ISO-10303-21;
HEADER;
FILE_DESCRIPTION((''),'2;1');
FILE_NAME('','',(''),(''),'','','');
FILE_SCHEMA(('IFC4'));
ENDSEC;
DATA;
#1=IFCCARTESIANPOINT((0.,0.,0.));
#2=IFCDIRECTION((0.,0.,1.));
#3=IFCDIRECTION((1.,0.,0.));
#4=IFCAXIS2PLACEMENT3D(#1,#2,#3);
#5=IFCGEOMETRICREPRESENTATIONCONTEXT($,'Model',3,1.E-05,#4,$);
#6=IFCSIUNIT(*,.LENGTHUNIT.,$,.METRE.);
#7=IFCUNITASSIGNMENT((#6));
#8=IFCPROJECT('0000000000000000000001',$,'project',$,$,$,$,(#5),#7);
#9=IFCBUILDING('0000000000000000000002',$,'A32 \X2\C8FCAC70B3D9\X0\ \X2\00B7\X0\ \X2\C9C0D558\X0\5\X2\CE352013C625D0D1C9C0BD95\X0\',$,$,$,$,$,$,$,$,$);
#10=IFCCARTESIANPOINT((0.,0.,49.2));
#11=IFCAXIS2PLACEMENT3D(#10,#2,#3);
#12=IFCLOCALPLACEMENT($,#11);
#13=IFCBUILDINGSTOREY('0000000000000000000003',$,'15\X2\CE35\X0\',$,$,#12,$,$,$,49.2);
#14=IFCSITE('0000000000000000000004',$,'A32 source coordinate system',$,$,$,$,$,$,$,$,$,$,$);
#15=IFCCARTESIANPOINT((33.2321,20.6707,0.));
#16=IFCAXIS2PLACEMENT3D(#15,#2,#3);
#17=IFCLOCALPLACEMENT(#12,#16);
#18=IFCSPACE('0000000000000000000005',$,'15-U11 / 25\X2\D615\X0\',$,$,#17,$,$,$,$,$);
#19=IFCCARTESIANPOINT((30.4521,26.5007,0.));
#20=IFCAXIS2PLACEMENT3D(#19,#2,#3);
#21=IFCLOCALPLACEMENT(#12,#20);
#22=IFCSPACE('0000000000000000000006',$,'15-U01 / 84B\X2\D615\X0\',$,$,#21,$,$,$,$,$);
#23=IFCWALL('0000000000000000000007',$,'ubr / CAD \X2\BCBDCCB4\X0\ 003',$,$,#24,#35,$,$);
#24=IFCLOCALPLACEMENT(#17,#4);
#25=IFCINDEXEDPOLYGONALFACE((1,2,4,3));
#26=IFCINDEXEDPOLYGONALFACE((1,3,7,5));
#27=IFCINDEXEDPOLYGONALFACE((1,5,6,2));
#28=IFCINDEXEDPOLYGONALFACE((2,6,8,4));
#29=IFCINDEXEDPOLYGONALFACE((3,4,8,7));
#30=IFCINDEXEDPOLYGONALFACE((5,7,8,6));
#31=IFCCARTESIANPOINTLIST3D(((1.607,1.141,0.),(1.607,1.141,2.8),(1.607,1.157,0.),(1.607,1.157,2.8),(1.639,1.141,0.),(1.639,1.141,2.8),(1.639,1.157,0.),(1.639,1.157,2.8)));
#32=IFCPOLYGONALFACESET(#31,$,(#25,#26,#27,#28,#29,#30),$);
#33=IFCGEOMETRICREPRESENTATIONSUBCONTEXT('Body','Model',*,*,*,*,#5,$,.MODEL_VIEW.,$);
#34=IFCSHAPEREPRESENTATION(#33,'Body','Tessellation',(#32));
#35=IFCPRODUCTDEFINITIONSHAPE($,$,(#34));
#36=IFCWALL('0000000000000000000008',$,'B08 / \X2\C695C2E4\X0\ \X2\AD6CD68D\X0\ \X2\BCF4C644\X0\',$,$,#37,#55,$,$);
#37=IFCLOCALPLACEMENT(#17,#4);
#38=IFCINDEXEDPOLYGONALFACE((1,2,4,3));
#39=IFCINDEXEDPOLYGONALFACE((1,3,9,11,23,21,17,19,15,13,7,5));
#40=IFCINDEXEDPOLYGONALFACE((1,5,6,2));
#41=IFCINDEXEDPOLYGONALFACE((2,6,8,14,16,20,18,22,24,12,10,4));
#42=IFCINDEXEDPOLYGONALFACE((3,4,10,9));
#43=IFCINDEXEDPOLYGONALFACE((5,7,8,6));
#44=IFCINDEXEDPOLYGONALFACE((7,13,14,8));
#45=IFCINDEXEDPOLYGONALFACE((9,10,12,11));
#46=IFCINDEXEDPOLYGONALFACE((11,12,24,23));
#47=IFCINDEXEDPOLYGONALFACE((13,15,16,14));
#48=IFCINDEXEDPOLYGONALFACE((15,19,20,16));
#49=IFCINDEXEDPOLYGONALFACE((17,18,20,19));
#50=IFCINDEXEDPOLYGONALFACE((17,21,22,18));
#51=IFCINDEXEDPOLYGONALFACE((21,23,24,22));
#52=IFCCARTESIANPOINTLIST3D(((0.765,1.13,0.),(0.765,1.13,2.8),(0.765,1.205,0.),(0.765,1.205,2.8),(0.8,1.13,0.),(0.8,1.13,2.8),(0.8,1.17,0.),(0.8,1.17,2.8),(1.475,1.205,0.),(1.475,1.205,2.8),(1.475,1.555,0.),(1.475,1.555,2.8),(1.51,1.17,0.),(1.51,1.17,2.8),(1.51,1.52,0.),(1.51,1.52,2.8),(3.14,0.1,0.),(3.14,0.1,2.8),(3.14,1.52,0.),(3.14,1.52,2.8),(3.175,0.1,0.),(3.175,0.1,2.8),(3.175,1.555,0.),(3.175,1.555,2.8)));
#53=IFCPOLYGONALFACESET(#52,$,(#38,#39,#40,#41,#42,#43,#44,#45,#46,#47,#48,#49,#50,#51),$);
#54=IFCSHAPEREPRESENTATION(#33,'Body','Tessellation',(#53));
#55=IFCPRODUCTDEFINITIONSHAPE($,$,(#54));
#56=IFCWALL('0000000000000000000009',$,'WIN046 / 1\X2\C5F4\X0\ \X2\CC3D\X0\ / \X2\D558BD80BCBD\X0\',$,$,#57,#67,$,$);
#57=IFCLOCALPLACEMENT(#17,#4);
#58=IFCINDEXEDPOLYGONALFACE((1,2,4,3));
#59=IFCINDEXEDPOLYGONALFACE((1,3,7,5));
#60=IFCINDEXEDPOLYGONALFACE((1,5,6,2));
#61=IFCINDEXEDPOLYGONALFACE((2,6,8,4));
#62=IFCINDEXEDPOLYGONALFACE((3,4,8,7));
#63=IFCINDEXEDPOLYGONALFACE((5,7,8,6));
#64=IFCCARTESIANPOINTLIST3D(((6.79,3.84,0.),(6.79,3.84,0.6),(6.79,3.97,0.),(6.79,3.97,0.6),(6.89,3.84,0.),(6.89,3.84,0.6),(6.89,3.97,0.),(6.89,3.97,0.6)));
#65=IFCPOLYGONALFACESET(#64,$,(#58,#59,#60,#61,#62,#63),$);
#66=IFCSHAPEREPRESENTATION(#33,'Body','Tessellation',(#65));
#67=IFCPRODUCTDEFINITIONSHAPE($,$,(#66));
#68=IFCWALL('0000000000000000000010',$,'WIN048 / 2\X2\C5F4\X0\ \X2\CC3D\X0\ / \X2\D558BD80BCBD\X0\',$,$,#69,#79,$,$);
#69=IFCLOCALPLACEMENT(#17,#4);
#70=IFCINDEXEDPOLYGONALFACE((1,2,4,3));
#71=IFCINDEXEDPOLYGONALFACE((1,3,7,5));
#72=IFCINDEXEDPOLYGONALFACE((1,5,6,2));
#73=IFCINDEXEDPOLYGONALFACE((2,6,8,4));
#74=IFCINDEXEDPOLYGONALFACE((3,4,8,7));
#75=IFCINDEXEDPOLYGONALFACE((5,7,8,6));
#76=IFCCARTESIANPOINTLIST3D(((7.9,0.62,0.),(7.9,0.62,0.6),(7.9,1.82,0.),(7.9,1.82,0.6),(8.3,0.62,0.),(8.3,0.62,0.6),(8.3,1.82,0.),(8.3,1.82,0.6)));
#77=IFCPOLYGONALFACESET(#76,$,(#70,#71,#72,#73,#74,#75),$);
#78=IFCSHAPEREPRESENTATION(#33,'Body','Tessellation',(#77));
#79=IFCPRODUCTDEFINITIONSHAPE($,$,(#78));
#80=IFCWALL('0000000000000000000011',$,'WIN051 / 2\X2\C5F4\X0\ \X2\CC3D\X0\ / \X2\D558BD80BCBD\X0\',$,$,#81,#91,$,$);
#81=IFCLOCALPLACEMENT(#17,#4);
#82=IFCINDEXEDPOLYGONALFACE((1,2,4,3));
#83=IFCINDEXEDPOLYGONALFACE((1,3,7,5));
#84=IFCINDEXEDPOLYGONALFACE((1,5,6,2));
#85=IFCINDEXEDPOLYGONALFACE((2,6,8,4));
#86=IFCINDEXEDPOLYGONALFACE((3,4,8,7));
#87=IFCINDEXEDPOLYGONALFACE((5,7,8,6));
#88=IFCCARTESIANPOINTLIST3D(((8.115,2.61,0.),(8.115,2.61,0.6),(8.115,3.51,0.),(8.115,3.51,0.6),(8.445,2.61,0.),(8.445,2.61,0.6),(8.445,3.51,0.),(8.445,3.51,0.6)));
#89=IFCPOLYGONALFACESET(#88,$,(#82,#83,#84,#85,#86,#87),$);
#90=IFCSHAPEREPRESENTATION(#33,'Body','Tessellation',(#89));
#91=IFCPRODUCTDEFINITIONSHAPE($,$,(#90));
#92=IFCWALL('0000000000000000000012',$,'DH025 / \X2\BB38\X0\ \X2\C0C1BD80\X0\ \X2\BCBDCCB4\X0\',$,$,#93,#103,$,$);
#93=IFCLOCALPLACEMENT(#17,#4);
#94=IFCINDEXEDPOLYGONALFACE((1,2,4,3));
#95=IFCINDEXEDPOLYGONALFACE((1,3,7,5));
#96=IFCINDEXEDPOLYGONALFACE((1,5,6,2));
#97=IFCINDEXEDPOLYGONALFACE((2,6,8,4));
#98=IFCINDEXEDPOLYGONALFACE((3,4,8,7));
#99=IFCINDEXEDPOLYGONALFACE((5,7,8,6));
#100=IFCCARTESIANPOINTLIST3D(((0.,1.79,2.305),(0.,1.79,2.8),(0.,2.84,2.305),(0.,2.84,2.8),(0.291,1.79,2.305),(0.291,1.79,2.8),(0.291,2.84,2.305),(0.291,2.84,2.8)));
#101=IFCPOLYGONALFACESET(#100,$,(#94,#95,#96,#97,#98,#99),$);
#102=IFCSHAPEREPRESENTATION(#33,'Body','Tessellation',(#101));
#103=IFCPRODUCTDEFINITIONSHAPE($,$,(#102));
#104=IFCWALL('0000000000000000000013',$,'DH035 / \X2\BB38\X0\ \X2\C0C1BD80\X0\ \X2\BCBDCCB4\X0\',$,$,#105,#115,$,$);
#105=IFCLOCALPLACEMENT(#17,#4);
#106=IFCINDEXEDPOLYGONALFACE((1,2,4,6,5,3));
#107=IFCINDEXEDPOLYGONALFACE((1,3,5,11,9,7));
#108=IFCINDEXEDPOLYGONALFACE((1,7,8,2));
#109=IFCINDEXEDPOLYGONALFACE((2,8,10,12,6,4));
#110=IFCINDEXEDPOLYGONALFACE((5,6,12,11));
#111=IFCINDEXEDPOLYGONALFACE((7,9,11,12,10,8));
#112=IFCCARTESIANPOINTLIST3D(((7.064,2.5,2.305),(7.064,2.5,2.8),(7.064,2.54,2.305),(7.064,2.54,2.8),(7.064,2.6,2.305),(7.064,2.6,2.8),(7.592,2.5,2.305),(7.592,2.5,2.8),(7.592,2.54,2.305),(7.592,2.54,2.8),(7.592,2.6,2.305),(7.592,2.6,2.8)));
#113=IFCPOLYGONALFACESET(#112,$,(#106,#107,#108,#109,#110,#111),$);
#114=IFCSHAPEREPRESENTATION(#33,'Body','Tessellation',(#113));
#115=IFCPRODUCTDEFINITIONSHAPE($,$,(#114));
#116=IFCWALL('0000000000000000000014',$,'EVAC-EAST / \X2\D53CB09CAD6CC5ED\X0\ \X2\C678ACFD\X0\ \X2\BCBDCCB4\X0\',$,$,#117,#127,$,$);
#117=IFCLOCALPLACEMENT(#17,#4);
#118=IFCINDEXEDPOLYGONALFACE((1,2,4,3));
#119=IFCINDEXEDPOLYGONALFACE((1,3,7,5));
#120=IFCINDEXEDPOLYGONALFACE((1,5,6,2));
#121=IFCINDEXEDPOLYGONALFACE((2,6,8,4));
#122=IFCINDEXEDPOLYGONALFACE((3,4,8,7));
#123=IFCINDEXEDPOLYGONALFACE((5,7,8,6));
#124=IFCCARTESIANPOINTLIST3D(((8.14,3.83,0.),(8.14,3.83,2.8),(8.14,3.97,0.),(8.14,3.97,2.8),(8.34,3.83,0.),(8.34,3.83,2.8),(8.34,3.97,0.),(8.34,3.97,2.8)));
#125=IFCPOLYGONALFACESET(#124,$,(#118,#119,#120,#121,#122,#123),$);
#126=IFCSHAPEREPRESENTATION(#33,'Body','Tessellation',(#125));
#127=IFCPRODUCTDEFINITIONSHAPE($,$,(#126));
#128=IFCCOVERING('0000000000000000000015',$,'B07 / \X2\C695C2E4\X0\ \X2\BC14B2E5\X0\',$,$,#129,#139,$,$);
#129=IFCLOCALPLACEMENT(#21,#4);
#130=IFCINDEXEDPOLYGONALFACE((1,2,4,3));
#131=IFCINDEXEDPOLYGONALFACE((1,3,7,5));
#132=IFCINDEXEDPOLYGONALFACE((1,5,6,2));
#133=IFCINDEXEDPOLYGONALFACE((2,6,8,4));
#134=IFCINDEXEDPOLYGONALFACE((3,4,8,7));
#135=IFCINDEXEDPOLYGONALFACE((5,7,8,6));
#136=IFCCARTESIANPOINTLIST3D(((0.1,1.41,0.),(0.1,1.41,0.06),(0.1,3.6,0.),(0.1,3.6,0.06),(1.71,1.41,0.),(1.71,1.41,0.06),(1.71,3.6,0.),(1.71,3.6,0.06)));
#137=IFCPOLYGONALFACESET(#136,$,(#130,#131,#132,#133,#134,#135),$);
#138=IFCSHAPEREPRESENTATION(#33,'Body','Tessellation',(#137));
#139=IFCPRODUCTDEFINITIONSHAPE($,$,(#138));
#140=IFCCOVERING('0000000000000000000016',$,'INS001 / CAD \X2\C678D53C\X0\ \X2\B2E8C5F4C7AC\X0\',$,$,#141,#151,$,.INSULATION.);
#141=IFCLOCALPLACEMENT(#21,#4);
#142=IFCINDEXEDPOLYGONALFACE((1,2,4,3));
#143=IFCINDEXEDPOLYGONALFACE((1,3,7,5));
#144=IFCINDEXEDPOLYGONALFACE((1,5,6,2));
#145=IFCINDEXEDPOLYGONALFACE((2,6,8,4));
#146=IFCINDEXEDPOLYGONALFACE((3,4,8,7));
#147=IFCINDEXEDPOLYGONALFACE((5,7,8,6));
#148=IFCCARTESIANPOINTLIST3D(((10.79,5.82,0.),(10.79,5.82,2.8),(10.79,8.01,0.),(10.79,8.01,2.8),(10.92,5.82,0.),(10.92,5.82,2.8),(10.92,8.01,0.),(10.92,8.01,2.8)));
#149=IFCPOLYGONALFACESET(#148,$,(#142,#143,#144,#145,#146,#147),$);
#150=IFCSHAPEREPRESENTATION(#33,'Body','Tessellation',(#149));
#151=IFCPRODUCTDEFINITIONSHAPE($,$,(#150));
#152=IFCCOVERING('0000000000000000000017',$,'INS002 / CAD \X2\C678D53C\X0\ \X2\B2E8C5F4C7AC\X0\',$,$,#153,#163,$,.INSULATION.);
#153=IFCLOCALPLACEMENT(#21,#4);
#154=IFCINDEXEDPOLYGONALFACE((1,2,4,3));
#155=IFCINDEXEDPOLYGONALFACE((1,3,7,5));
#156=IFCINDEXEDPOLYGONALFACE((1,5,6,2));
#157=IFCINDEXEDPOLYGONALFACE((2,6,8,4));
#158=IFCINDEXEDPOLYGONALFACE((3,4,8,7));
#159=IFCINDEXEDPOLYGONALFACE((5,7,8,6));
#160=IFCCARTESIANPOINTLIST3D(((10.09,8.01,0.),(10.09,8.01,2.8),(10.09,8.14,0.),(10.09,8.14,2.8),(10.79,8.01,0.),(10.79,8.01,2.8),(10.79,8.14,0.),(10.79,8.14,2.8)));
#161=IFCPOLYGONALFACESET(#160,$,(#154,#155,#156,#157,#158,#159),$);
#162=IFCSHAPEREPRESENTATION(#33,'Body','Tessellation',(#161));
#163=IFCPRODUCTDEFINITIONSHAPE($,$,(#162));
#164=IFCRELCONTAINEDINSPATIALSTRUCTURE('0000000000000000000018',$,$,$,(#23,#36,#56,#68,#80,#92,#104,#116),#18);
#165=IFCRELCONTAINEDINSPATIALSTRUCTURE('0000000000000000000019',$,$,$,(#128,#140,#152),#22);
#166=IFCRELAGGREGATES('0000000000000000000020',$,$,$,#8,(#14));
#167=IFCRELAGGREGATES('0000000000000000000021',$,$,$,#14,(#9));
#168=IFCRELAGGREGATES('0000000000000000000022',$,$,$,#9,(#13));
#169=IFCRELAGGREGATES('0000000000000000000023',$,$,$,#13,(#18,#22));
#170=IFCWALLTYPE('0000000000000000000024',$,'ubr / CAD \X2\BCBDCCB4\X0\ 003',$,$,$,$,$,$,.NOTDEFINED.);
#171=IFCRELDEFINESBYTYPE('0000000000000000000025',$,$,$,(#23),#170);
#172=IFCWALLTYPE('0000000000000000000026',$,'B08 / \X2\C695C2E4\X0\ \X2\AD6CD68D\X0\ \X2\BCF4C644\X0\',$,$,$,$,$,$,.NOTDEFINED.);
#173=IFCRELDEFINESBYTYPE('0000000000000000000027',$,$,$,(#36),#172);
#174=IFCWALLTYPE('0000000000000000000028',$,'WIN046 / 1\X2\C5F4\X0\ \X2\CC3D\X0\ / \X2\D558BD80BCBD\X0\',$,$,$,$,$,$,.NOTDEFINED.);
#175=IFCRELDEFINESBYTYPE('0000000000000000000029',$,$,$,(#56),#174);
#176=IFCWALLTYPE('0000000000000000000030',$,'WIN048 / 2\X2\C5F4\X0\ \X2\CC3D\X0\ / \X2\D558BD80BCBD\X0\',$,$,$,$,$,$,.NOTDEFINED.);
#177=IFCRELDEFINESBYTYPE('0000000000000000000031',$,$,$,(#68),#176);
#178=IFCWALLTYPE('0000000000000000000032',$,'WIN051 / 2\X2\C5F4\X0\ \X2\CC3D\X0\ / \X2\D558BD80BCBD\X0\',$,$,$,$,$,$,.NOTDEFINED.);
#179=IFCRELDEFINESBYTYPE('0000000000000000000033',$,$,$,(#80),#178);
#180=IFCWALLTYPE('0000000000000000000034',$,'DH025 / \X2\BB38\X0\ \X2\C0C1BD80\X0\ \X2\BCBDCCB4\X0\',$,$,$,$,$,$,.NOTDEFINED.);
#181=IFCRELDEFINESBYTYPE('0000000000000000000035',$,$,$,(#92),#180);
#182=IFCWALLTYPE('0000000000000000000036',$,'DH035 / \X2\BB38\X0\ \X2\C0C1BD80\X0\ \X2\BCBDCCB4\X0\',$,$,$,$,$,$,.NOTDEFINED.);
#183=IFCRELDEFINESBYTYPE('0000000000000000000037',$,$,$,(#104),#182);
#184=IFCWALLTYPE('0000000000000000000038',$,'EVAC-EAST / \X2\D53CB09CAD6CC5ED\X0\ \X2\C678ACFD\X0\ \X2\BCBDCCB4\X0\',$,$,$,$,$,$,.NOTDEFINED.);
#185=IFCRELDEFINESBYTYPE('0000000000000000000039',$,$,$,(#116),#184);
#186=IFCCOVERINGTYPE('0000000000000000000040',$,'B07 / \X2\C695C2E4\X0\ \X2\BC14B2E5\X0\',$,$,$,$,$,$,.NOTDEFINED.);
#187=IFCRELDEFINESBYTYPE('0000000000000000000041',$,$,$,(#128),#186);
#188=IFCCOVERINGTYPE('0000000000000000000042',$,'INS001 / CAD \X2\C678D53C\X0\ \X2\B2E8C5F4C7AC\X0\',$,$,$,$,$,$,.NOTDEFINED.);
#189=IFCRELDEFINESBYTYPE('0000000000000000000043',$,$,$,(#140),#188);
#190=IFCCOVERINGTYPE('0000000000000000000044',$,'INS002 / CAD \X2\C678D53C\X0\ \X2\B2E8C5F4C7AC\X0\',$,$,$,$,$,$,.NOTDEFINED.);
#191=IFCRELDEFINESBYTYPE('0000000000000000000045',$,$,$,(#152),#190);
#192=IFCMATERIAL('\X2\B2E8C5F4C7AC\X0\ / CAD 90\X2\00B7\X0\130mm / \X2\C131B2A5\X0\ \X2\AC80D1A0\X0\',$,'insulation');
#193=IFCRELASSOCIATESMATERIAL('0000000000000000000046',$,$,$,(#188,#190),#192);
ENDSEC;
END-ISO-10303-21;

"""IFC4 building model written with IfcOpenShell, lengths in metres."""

from ifc_helpers import new_model, si_unit, frame, origin, origin_with_axes, place, context, subcontext, project, spatial, polyline, outline, extrude, source, transform, mapped, material, type_object, type_shapes, element, save


model = new_model("IFC4")

# Units and contexts
model_context = context("Model", 3, precision=1e-05, world=origin_with_axes())
body_context = subcontext(model_context, "Body", "Model", "MODEL_VIEW")
ifc_project = project(units=[si_unit("LENGTHUNIT", "METRE")], contexts=[model_context])

# Site, building, storey, space
site = spatial("IfcSite", under=ifc_project, Name="A32 source coordinate system")
building = spatial("IfcBuilding", under=site, Name="A32 주거동 · 지하5층–옥탑지붕")
storey_placement = place(None, frame((0.0, 0.0, 49.2), z_axis=(0.0, 0.0, 1.0), x_axis=(1.0, 0.0, 0.0)))
storey = spatial("IfcBuildingStorey", under=building, at=storey_placement, Name="15층", Elevation=49.2)
space_1_placement = place(storey_placement, frame((33.2321, 20.6707, 0.0), z_axis=(0.0, 0.0, 1.0), x_axis=(1.0, 0.0, 0.0)))
space_1 = spatial("IfcSpace", under=storey, at=space_1_placement, Name="15-U11 / 25형")

# Walls
wall_type_1 = type_object("IfcWallType", Name="ubr / CAD 벽체 003", PredefinedType="NOTDEFINED")
shared_shape_1 = source(origin(), body_context, "Body", "SweptSolid", [
    extrude(outline(polyline([(1.639, 1.157), (1.639, 1.141), (1.607, 1.141), (1.607, 1.157), (1.639, 1.157)])), origin(), (0.0, 0.0, 1.0), 2.8),
])
type_shapes(wall_type_1, [shared_shape_1])
wall_1_placement = place(space_1_placement, origin_with_axes())
element("IfcWall", 1, at=wall_1_placement, inside=space_1, type_object=wall_type_1, Name="ubr / CAD 벽체 003", context=body_context, shape_type="MappedRepresentation", body=[
    mapped(shared_shape_1, transform((0.0, 0.0, 0.0), scale=1.0)),
])
wall_type_2 = type_object("IfcWallType", Name="B08 / 욕실 구획 보완", PredefinedType="NOTDEFINED")
shared_shape_2 = source(origin(), body_context, "Body", "SweptSolid", [
    extrude(outline(polyline([(0.765, 1.205), (1.475, 1.205), (1.475, 1.555), (3.175, 1.555), (3.175, 0.1), (3.14, 0.1), (3.14, 1.52), (1.51, 1.52), (1.51, 1.17), (0.8, 1.17), (0.8, 1.13), (0.765, 1.13), (0.765, 1.205)])), origin(), (0.0, 0.0, 1.0), 2.8),
])
type_shapes(wall_type_2, [shared_shape_2])
wall_2_placement = place(space_1_placement, origin_with_axes())
element("IfcWall", 2, at=wall_2_placement, inside=space_1, type_object=wall_type_2, Name="B08 / 욕실 구획 보완", context=body_context, shape_type="MappedRepresentation", body=[
    mapped(shared_shape_2, transform((0.0, 0.0, 0.0), scale=1.0)),
])
wall_type_3 = type_object("IfcWallType", Name="WIN046 / 1열 창 / 하부벽", PredefinedType="NOTDEFINED")
shared_shape_3 = source(origin(), body_context, "Body", "SweptSolid", [
    extrude(outline(polyline([(6.89, 3.84), (6.79, 3.84), (6.79, 3.97), (6.89, 3.97), (6.89, 3.84)])), origin(), (0.0, 0.0, 1.0), 0.6),
])
type_shapes(wall_type_3, [shared_shape_3])
wall_3_placement = place(space_1_placement, origin_with_axes())
element("IfcWall", 3, at=wall_3_placement, inside=space_1, type_object=wall_type_3, Name="WIN046 / 1열 창 / 하부벽", context=body_context, shape_type="MappedRepresentation", body=[
    mapped(shared_shape_3, transform((0.0, 0.0, 0.0), scale=1.0)),
])
wall_type_4 = type_object("IfcWallType", Name="WIN048 / 2열 창 / 하부벽", PredefinedType="NOTDEFINED")
shared_shape_4 = source(origin(), body_context, "Body", "SweptSolid", [
    extrude(outline(polyline([(8.3, 0.62), (7.9, 0.62), (7.9, 1.82), (8.3, 1.82), (8.3, 0.62)])), origin(), (0.0, 0.0, 1.0), 0.6),
])
type_shapes(wall_type_4, [shared_shape_4])
wall_4_placement = place(space_1_placement, origin_with_axes())
element("IfcWall", 4, at=wall_4_placement, inside=space_1, type_object=wall_type_4, Name="WIN048 / 2열 창 / 하부벽", context=body_context, shape_type="MappedRepresentation", body=[
    mapped(shared_shape_4, transform((0.0, 0.0, 0.0), scale=1.0)),
])
wall_type_5 = type_object("IfcWallType", Name="WIN051 / 2열 창 / 하부벽", PredefinedType="NOTDEFINED")
shared_shape_5 = source(origin(), body_context, "Body", "SweptSolid", [
    extrude(outline(polyline([(8.445, 2.61), (8.115, 2.61), (8.115, 3.51), (8.445, 3.51), (8.445, 2.61)])), origin(), (0.0, 0.0, 1.0), 0.6),
])
type_shapes(wall_type_5, [shared_shape_5])
wall_5_placement = place(space_1_placement, origin_with_axes())
element("IfcWall", 5, at=wall_5_placement, inside=space_1, type_object=wall_type_5, Name="WIN051 / 2열 창 / 하부벽", context=body_context, shape_type="MappedRepresentation", body=[
    mapped(shared_shape_5, transform((0.0, 0.0, 0.0), scale=1.0)),
])
wall_type_6 = type_object("IfcWallType", Name="DH025 / 문 상부 벽체", PredefinedType="NOTDEFINED")
shared_shape_6 = source(origin(), body_context, "Body", "SweptSolid", [
    extrude(outline(polyline([(0.0, 1.79), (0.0, 2.84), (0.291, 2.84), (0.291, 1.79), (0.0, 1.79)])), frame((0.0, 0.0, 2.305)), (0.0, 0.0, 1.0), 0.495),
])
type_shapes(wall_type_6, [shared_shape_6])
wall_6_placement = place(space_1_placement, origin_with_axes())
element("IfcWall", 6, at=wall_6_placement, inside=space_1, type_object=wall_type_6, Name="DH025 / 문 상부 벽체", context=body_context, shape_type="MappedRepresentation", body=[
    mapped(shared_shape_6, transform((0.0, 0.0, 0.0), scale=1.0)),
])
wall_type_7 = type_object("IfcWallType", Name="DH035 / 문 상부 벽체", PredefinedType="NOTDEFINED")
shared_shape_7 = source(origin(), body_context, "Body", "SweptSolid", [
    extrude(outline(polyline([(7.592, 2.6), (7.592, 2.54), (7.592, 2.5), (7.064, 2.5), (7.064, 2.54), (7.064, 2.6), (7.592, 2.6)])), frame((0.0, 0.0, 2.305)), (0.0, 0.0, 1.0), 0.495),
])
type_shapes(wall_type_7, [shared_shape_7])
wall_7_placement = place(space_1_placement, origin_with_axes())
element("IfcWall", 7, at=wall_7_placement, inside=space_1, type_object=wall_type_7, Name="DH035 / 문 상부 벽체", context=body_context, shape_type="MappedRepresentation", body=[
    mapped(shared_shape_7, transform((0.0, 0.0, 0.0), scale=1.0)),
])
wall_type_8 = type_object("IfcWallType", Name="EVAC-EAST / 피난구역 외곽 벽체", PredefinedType="NOTDEFINED")
shared_shape_8 = source(origin(), body_context, "Body", "SweptSolid", [
    extrude(outline(polyline([(8.34, 3.83), (8.14, 3.83), (8.14, 3.97), (8.34, 3.97), (8.34, 3.83)])), origin(), (0.0, 0.0, 1.0), 2.8),
])
type_shapes(wall_type_8, [shared_shape_8])
wall_8_placement = place(space_1_placement, origin_with_axes())
element("IfcWall", 8, at=wall_8_placement, inside=space_1, type_object=wall_type_8, Name="EVAC-EAST / 피난구역 외곽 벽체", context=body_context, shape_type="MappedRepresentation", body=[
    mapped(shared_shape_8, transform((0.0, 0.0, 0.0), scale=1.0)),
])

# Shared definitions
space_2_placement = place(storey_placement, frame((30.4521, 26.5007, 0.0), z_axis=(0.0, 0.0, 1.0), x_axis=(1.0, 0.0, 0.0)))
space_2 = spatial("IfcSpace", under=storey, at=space_2_placement, Name="15-U01 / 84B형")

# Coverings
covering_type_1 = type_object("IfcCoveringType", Name="B07 / 욕실 바닥", PredefinedType="NOTDEFINED")
shared_shape_9 = source(origin(), body_context, "Body", "SweptSolid", [
    extrude(outline(polyline([(1.71, 1.41), (0.1, 1.41), (0.1, 3.6), (1.71, 3.6), (1.71, 1.41)])), origin(), (0.0, 0.0, 1.0), 0.06),
])
type_shapes(covering_type_1, [shared_shape_9])
covering_1_placement = place(space_2_placement, origin_with_axes())
element("IfcCovering", 9, at=covering_1_placement, inside=space_2, type_object=covering_type_1, Name="B07 / 욕실 바닥", context=body_context, shape_type="MappedRepresentation", body=[
    mapped(shared_shape_9, transform((0.0, 0.0, 0.0), scale=1.0)),
])
ifc_material = material(Name="단열재 / CAD 90·130mm / 성능 검토", Category="insulation")
covering_type_2 = type_object("IfcCoveringType", Name="INS001 / CAD 외피 단열재", PredefinedType="NOTDEFINED", material=ifc_material)
shared_shape_10 = source(origin(), body_context, "Body", "SweptSolid", [
    extrude(outline(polyline([(10.79, 5.82), (10.79, 8.01), (10.92, 8.01), (10.92, 5.82), (10.79, 5.82)])), origin(), (0.0, 0.0, 1.0), 2.8),
])
type_shapes(covering_type_2, [shared_shape_10])
covering_2_placement = place(space_2_placement, origin_with_axes())
element("IfcCovering", 10, at=covering_2_placement, inside=space_2, type_object=covering_type_2, Name="INS001 / CAD 외피 단열재", PredefinedType="INSULATION", context=body_context, shape_type="MappedRepresentation", body=[
    mapped(shared_shape_10, transform((0.0, 0.0, 0.0), scale=1.0)),
])
covering_type_3 = type_object("IfcCoveringType", Name="INS002 / CAD 외피 단열재", PredefinedType="NOTDEFINED", material=ifc_material)
shared_shape_11 = source(origin(), body_context, "Body", "SweptSolid", [
    extrude(outline(polyline([(10.79, 8.01), (10.09, 8.01), (10.09, 8.14), (10.79, 8.14), (10.79, 8.01)])), origin(), (0.0, 0.0, 1.0), 2.8),
])
type_shapes(covering_type_3, [shared_shape_11])
covering_3_placement = place(space_2_placement, origin_with_axes())
element("IfcCovering", 11, at=covering_3_placement, inside=space_2, type_object=covering_type_3, Name="INS002 / CAD 외피 단열재", PredefinedType="INSULATION", context=body_context, shape_type="MappedRepresentation", body=[
    mapped(shared_shape_11, transform((0.0, 0.0, 0.0), scale=1.0)),
])

save(model, "model.ifc")
